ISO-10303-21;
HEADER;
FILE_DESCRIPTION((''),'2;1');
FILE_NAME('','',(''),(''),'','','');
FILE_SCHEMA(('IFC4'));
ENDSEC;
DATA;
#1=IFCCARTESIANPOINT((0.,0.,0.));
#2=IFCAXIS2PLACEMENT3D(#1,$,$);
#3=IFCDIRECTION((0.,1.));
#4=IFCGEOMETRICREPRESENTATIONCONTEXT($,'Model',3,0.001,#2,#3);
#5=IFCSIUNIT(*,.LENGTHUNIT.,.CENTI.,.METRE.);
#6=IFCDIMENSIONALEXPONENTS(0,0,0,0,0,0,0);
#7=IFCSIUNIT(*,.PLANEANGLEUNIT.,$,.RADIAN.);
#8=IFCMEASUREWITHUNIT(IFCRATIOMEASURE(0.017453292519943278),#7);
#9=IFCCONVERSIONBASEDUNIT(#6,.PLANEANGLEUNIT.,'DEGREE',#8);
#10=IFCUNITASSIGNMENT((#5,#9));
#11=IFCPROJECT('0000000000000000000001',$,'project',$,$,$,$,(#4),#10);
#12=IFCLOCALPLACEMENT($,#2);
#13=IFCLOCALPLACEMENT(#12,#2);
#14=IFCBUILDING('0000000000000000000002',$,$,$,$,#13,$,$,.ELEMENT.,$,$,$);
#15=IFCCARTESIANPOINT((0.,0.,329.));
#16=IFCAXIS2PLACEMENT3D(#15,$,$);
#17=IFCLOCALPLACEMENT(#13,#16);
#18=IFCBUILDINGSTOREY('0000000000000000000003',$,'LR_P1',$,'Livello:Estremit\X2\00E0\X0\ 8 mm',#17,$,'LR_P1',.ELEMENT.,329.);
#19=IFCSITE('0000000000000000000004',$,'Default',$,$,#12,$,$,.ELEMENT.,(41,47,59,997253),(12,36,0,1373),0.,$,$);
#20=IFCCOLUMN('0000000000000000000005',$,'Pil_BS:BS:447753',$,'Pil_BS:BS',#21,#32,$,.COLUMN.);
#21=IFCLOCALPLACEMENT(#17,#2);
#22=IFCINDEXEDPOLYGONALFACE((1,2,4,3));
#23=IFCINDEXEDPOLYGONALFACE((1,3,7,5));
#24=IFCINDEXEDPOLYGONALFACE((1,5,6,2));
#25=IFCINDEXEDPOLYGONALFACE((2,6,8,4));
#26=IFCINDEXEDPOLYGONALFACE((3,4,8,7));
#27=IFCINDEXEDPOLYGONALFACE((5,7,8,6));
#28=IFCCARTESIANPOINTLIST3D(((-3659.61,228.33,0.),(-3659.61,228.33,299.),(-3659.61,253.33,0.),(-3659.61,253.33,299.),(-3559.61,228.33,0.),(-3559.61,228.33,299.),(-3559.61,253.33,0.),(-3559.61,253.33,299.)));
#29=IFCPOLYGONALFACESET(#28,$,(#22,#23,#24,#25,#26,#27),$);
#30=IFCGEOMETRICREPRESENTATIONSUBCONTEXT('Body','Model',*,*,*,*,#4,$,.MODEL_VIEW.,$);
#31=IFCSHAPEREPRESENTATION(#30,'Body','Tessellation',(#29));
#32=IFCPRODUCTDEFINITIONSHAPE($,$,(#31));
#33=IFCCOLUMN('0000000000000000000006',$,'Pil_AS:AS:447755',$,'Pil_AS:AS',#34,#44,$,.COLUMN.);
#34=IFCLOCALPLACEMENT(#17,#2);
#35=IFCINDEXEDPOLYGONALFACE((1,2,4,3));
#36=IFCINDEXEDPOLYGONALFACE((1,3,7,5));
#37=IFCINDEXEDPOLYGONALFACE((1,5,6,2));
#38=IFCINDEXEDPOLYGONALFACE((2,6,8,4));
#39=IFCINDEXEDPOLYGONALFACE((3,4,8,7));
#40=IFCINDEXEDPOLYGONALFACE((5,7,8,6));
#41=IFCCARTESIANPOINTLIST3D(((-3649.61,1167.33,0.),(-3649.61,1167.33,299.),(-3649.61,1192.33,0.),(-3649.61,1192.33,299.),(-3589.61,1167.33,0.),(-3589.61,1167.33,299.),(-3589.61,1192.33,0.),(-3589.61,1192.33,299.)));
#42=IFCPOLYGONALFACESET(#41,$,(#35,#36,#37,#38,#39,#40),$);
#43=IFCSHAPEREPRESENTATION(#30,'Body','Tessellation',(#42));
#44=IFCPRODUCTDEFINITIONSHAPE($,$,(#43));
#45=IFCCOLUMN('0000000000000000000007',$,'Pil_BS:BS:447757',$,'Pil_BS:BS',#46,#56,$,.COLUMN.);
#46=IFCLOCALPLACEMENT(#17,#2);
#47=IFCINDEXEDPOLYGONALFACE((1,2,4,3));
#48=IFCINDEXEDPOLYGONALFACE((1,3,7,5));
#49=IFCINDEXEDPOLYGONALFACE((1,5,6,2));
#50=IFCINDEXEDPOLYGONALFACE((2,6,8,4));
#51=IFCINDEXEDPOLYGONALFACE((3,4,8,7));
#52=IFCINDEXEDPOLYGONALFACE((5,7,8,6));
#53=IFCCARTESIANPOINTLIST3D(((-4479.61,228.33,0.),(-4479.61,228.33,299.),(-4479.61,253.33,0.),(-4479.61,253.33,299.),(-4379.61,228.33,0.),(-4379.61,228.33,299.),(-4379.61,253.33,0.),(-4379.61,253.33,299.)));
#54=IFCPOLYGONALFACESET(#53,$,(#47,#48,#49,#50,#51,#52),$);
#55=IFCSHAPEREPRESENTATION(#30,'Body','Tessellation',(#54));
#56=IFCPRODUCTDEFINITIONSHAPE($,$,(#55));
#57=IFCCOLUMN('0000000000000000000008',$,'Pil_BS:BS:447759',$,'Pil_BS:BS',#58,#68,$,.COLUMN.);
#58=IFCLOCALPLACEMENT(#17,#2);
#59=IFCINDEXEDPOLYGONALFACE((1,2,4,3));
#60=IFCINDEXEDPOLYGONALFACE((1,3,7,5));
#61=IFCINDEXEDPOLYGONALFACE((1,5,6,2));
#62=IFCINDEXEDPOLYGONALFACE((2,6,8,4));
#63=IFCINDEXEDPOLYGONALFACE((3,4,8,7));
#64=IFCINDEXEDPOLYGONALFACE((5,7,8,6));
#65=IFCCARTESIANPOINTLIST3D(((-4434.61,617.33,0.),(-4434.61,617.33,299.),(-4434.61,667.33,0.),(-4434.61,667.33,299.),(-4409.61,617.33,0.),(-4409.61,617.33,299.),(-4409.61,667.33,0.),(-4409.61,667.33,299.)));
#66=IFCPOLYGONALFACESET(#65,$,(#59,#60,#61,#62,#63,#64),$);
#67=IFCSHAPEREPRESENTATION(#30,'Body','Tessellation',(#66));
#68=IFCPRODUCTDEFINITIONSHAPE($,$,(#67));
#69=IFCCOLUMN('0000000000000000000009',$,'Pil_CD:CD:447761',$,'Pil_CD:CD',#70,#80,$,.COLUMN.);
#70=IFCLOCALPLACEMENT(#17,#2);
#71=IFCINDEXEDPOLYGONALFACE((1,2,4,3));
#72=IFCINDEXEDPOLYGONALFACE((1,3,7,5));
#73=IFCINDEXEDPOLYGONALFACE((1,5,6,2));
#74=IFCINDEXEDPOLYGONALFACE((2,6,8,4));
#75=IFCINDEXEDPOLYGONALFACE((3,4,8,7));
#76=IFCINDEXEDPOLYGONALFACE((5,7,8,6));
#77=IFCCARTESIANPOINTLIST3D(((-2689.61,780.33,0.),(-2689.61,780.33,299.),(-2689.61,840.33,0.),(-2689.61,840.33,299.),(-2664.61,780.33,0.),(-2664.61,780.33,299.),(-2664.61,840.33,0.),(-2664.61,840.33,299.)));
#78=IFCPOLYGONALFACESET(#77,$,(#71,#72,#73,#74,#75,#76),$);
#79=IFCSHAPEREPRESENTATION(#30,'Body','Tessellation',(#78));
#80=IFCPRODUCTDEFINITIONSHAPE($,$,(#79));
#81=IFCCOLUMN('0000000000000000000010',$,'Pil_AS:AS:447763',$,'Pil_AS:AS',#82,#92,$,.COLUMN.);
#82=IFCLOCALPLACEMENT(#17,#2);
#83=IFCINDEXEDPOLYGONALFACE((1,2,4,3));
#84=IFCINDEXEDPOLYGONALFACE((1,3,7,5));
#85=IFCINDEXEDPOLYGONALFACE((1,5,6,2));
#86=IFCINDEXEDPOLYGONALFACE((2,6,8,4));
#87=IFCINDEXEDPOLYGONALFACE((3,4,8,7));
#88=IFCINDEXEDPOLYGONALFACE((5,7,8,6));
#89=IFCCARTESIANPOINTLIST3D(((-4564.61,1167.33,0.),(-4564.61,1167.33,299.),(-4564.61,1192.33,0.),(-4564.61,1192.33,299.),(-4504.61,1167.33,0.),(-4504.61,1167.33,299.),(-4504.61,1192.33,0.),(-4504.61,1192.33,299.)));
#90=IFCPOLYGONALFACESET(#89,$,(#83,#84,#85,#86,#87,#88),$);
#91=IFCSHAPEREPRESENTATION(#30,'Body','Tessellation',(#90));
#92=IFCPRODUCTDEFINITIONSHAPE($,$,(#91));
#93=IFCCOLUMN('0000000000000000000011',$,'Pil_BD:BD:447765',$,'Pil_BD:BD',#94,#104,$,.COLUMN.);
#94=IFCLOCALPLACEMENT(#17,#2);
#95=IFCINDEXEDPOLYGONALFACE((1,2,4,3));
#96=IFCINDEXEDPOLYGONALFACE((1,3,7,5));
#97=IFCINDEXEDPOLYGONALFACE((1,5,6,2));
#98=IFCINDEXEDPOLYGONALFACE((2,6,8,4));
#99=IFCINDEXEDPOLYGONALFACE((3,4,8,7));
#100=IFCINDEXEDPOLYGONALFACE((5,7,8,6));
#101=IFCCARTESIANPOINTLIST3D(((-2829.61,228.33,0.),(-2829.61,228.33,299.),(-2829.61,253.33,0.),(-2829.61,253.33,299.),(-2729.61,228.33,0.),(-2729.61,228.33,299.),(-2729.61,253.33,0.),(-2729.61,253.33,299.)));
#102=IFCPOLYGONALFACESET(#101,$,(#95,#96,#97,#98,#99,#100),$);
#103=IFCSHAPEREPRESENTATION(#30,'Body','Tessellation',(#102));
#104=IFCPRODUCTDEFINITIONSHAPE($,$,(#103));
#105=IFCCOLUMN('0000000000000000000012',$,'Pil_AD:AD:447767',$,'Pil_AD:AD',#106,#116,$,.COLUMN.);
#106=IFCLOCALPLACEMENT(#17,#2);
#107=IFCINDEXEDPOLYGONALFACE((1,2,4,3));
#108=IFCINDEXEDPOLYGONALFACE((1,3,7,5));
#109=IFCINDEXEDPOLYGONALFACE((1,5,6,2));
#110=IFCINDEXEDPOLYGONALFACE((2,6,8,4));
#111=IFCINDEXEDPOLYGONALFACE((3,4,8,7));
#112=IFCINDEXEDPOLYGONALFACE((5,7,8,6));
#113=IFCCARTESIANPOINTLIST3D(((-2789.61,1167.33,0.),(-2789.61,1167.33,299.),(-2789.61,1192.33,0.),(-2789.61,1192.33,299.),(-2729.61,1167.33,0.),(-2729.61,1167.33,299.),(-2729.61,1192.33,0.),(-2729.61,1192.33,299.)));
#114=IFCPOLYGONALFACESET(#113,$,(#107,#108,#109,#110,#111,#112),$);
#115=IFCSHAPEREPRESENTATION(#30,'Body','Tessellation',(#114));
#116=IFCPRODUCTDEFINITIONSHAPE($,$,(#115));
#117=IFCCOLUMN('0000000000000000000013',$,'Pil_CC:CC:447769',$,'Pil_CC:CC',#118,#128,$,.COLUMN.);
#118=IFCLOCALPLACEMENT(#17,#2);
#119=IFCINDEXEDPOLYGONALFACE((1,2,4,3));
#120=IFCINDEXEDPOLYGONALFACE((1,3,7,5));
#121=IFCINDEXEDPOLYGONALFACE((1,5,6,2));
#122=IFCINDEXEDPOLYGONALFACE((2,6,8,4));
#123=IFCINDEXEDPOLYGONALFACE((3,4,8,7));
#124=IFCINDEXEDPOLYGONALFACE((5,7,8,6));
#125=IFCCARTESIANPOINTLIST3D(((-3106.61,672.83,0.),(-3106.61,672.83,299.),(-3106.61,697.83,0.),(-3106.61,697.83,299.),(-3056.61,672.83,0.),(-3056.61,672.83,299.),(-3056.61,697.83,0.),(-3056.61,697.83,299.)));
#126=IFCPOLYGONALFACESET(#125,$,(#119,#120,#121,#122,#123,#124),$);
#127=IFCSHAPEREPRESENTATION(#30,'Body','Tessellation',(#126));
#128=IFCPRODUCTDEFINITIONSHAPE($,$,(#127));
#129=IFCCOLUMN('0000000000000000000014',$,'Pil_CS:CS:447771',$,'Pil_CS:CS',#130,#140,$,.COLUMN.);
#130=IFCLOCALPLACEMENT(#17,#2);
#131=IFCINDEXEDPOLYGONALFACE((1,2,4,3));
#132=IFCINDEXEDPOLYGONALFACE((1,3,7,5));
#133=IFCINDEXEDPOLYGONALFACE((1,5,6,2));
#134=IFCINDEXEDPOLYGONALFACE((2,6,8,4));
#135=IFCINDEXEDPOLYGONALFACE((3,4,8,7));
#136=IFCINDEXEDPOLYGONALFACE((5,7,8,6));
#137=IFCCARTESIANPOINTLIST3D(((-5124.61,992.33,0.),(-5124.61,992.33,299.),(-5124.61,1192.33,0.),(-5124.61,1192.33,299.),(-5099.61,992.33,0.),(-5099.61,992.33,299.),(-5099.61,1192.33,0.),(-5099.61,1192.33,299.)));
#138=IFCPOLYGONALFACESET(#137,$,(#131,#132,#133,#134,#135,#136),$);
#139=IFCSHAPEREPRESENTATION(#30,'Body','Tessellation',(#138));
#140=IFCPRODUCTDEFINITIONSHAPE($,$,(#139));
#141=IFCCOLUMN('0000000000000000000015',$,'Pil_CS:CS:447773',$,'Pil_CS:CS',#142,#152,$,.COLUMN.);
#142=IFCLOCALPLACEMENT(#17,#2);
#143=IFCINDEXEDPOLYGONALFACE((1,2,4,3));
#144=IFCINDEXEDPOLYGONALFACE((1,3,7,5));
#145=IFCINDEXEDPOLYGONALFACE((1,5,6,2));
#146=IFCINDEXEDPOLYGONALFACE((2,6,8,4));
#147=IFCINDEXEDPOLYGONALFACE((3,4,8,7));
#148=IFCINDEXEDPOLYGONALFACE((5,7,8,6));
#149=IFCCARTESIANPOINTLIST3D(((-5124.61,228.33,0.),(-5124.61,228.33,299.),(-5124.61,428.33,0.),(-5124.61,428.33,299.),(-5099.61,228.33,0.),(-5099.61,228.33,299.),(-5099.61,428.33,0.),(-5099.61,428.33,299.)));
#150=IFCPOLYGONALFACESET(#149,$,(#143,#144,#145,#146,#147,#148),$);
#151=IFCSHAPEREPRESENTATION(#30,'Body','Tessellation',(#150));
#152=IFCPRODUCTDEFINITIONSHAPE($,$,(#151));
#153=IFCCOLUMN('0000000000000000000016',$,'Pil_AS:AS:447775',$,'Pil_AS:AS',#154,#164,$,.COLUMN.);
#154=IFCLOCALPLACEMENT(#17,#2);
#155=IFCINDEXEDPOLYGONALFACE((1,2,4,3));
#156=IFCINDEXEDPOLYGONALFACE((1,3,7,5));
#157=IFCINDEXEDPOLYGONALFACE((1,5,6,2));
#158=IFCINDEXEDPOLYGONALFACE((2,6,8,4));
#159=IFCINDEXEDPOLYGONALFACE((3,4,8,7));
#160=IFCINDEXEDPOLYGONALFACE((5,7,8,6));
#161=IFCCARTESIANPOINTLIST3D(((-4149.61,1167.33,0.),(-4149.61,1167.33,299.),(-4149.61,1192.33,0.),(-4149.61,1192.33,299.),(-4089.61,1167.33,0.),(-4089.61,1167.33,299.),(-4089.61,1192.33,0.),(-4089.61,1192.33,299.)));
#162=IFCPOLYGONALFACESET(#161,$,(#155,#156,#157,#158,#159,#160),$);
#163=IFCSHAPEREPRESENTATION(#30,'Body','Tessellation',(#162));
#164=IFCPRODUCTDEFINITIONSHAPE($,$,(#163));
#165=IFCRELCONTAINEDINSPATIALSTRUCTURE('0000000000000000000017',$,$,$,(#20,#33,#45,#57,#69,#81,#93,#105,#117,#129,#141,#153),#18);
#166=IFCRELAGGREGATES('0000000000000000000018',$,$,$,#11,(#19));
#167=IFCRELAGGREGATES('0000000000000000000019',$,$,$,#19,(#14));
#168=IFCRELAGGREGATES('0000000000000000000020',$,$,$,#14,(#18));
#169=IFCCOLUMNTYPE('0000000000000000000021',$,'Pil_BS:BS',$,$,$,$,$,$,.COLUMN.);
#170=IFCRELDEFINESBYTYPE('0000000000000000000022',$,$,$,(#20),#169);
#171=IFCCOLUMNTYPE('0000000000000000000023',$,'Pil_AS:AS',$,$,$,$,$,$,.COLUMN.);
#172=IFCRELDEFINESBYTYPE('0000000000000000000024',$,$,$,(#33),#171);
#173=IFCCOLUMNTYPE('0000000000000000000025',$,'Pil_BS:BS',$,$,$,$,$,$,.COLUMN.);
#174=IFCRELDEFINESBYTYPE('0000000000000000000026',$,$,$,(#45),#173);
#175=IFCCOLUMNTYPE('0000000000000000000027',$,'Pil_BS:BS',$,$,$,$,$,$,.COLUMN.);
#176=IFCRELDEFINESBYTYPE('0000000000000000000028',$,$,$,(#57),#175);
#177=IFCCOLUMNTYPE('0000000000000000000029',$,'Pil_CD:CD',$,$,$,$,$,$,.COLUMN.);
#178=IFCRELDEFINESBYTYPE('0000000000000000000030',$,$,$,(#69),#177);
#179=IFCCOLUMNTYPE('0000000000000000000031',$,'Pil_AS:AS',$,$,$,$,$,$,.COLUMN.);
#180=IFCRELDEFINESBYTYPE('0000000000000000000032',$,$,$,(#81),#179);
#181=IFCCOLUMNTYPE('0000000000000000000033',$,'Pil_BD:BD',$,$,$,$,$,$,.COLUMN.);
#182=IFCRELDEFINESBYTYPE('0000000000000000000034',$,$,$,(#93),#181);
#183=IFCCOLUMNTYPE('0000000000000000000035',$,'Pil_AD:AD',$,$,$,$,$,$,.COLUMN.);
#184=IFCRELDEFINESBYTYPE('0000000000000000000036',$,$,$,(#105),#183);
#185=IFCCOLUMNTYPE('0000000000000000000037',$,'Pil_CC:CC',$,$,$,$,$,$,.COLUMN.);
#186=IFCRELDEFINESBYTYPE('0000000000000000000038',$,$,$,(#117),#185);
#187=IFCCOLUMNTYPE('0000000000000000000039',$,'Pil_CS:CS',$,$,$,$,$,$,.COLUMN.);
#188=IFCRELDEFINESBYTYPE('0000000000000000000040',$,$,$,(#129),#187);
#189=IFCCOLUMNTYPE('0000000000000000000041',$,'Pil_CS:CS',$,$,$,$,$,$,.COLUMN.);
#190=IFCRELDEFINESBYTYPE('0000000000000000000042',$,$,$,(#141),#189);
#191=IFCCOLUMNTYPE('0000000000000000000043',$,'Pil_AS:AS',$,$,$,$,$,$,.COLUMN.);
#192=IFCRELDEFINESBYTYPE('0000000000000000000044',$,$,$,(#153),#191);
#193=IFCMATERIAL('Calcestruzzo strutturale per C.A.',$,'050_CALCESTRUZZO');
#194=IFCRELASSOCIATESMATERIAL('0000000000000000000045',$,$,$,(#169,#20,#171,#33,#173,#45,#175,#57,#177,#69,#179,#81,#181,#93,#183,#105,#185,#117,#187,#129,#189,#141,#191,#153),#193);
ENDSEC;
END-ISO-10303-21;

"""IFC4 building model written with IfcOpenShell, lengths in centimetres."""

from ifc_helpers import new_model, entity, si_unit, converted_unit, direction, frame, origin, place, context, subcontext, project, spatial, indexed_curve, outline, extrude, source, transform, mapped, material, type_object, type_shapes, element, save


model = new_model("IFC4")

# Units and contexts
model_context = context("Model", 3, precision=0.001, world=origin(), true_north=direction((0.0, 1.0)))
body_context = subcontext(model_context, "Body", "Model", "MODEL_VIEW")
ifc_project = project(units=[si_unit("LENGTHUNIT", "METRE", prefix="CENTI"), converted_unit("PLANEANGLEUNIT", "DEGREE", entity("IfcRatioMeasure", 0.017453292519943278), si_unit("PLANEANGLEUNIT", "RADIAN"), dimensions=[0, 0, 0, 0, 0, 0, 0])], contexts=[model_context])

# Site, building, storey
site_placement = place(None, origin())
site = spatial("IfcSite", under=ifc_project, at=site_placement, Name="Default", CompositionType="ELEMENT", RefLatitude=(41, 47, 59, 997253), RefLongitude=(12, 36, 0, 1373), RefElevation=0.0)
building_placement = place(site_placement, origin())
building = spatial("IfcBuilding", under=site, at=building_placement, CompositionType="ELEMENT")
storey_placement = place(building_placement, frame((0.0, 0.0, 329.0)))
storey = spatial("IfcBuildingStorey", under=building, at=storey_placement, Name="LR_P1", ObjectType="Livello:Estremità 8 mm", LongName="LR_P1", CompositionType="ELEMENT", Elevation=329.0)

# Columns
ifc_material_1 = material(Name="Calcestruzzo strutturale per C.A.", Category="050_CALCESTRUZZO")
column_type_1 = type_object("IfcColumnType", Name="Pil_BS:BS", PredefinedType="COLUMN", material=ifc_material_1)
shared_shape_1 = source(origin(), body_context, "Body", "SweptSolid", [
    extrude(outline(indexed_curve([(-12.5, -50.0), (12.5, -50.0), (12.5, 50.0), (-12.5, 50.0), (-12.5, -50.0)], self_intersect=False)), frame((-3609.61, 240.83, 329.0), z_axis=(0.0, 0.0, 1.0), x_axis=(0.0, -1.0, 0.0)), (0.0, 0.0, 1.0), 299.0),
])
type_shapes(column_type_1, [shared_shape_1])
column_1_placement = place(storey_placement, frame((0.0, 0.0, -329.0)))
element("IfcColumn", 1, at=column_1_placement, inside=storey, type_object=column_type_1, material=ifc_material_1, Name="Pil_BS:BS:447753", ObjectType="Pil_BS:BS", PredefinedType="COLUMN", context=body_context, shape_type="MappedRepresentation", body=[
    mapped(shared_shape_1, transform((0.0, 0.0, 0.0), scale=1.0)),
])
column_type_2 = type_object("IfcColumnType", Name="Pil_AS:AS", PredefinedType="COLUMN", material=ifc_material_1)
shared_shape_2 = source(origin(), body_context, "Body", "SweptSolid", [
    extrude(outline(indexed_curve([(-12.5, -30.0), (12.5, -30.0), (12.5, 30.0), (-12.5, 30.0), (-12.5, -30.0)], self_intersect=False)), frame((-3619.61, 1179.83, 329.0), z_axis=(0.0, 0.0, 1.0), x_axis=(0.0, -1.0, 0.0)), (0.0, 0.0, 1.0), 299.0),
])
type_shapes(column_type_2, [shared_shape_2])
column_2_placement = place(storey_placement, frame((0.0, 0.0, -329.0)))
element("IfcColumn", 2, at=column_2_placement, inside=storey, type_object=column_type_2, material=ifc_material_1, Name="Pil_AS:AS:447755", ObjectType="Pil_AS:AS", PredefinedType="COLUMN", context=body_context, shape_type="MappedRepresentation", body=[
    mapped(shared_shape_2, transform((0.0, 0.0, 0.0), scale=1.0)),
])
column_type_3 = type_object("IfcColumnType", Name="Pil_BS:BS", PredefinedType="COLUMN", material=ifc_material_1)
shared_shape_3 = source(origin(), body_context, "Body", "SweptSolid", [
    extrude(outline(indexed_curve([(-12.5, -50.0), (12.5, -50.0), (12.5, 50.0), (-12.5, 50.0), (-12.5, -50.0)], self_intersect=False)), frame((-4429.61, 240.83, 329.0), z_axis=(0.0, 0.0, 1.0), x_axis=(0.0, -1.0, 0.0)), (0.0, 0.0, 1.0), 299.0),
])
type_shapes(column_type_3, [shared_shape_3])
column_3_placement = place(storey_placement, frame((0.0, 0.0, -329.0)))
element("IfcColumn", 3, at=column_3_placement, inside=storey, type_object=column_type_3, material=ifc_material_1, Name="Pil_BS:BS:447757", ObjectType="Pil_BS:BS", PredefinedType="COLUMN", context=body_context, shape_type="MappedRepresentation", body=[
    mapped(shared_shape_3, transform((0.0, 0.0, 0.0), scale=1.0)),
])
column_type_4 = type_object("IfcColumnType", Name="Pil_BS:BS", PredefinedType="COLUMN", material=ifc_material_1)
shared_shape_4 = source(origin(), body_context, "Body", "SweptSolid", [
    extrude(outline(indexed_curve([(-25.0, -12.5), (25.0, -12.5), (25.0, 12.5), (-25.0, 12.5), (-25.0, -12.5)], self_intersect=False)), frame((-4422.11, 642.33, 329.0), z_axis=(0.0, 0.0, 1.0), x_axis=(0.0, -1.0, 0.0)), (0.0, 0.0, 1.0), 299.0),
])
type_shapes(column_type_4, [shared_shape_4])
column_4_placement = place(storey_placement, frame((0.0, 0.0, -329.0)))
element("IfcColumn", 4, at=column_4_placement, inside=storey, type_object=column_type_4, material=ifc_material_1, Name="Pil_BS:BS:447759", ObjectType="Pil_BS:BS", PredefinedType="COLUMN", context=body_context, shape_type="MappedRepresentation", body=[
    mapped(shared_shape_4, transform((0.0, 0.0, 0.0), scale=1.0)),
])
column_type_5 = type_object("IfcColumnType", Name="Pil_CD:CD", PredefinedType="COLUMN", material=ifc_material_1)
shared_shape_5 = source(origin(), body_context, "Body", "SweptSolid", [
    extrude(outline(indexed_curve([(-30.0, -12.5), (30.0, -12.5), (30.0, 12.5), (-30.0, 12.5), (-30.0, -12.5)], self_intersect=False)), frame((-2677.11, 810.33, 329.0), z_axis=(0.0, 0.0, 1.0), x_axis=(0.0, -1.0, 0.0)), (0.0, 0.0, 1.0), 299.0),
])
type_shapes(column_type_5, [shared_shape_5])
column_5_placement = place(storey_placement, frame((0.0, 0.0, -329.0)))
element("IfcColumn", 5, at=column_5_placement, inside=storey, type_object=column_type_5, material=ifc_material_1, Name="Pil_CD:CD:447761", ObjectType="Pil_CD:CD", PredefinedType="COLUMN", context=body_context, shape_type="MappedRepresentation", body=[
    mapped(shared_shape_5, transform((0.0, 0.0, 0.0), scale=1.0)),
])
column_type_6 = type_object("IfcColumnType", Name="Pil_AS:AS", PredefinedType="COLUMN", material=ifc_material_1)
shared_shape_6 = source(origin(), body_context, "Body", "SweptSolid", [
    extrude(outline(indexed_curve([(-12.5, -30.0), (12.5, -30.0), (12.5, 30.0), (-12.5, 30.0), (-12.5, -30.0)], self_intersect=False)), frame((-4534.61, 1179.83, 329.0), z_axis=(0.0, 0.0, 1.0), x_axis=(0.0, -1.0, 0.0)), (0.0, 0.0, 1.0), 299.0),
])
type_shapes(column_type_6, [shared_shape_6])
column_6_placement = place(storey_placement, frame((0.0, 0.0, -329.0)))
element("IfcColumn", 6, at=column_6_placement, inside=storey, type_object=column_type_6, material=ifc_material_1, Name="Pil_AS:AS:447763", ObjectType="Pil_AS:AS", PredefinedType="COLUMN", context=body_context, shape_type="MappedRepresentation", body=[
    mapped(shared_shape_6, transform((0.0, 0.0, 0.0), scale=1.0)),
])
column_type_7 = type_object("IfcColumnType", Name="Pil_BD:BD", PredefinedType="COLUMN", material=ifc_material_1)
shared_shape_7 = source(origin(), body_context, "Body", "SweptSolid", [
    extrude(outline(indexed_curve([(-12.5, -50.0), (12.5, -50.0), (12.5, 50.0), (-12.5, 50.0), (-12.5, -50.0)], self_intersect=False)), frame((-2779.61, 240.83, 329.0), z_axis=(0.0, 0.0, 1.0), x_axis=(0.0, -1.0, 0.0)), (0.0, 0.0, 1.0), 299.0),
])
type_shapes(column_type_7, [shared_shape_7])
column_7_placement = place(storey_placement, frame((0.0, 0.0, -329.0)))
element("IfcColumn", 7, at=column_7_placement, inside=storey, type_object=column_type_7, material=ifc_material_1, Name="Pil_BD:BD:447765", ObjectType="Pil_BD:BD", PredefinedType="COLUMN", context=body_context, shape_type="MappedRepresentation", body=[
    mapped(shared_shape_7, transform((0.0, 0.0, 0.0), scale=1.0)),
])
column_type_8 = type_object("IfcColumnType", Name="Pil_AD:AD", PredefinedType="COLUMN", material=ifc_material_1)
shared_shape_8 = source(origin(), body_context, "Body", "SweptSolid", [
    extrude(outline(indexed_curve([(-12.5, -30.0), (12.5, -30.0), (12.5, 30.0), (-12.5, 30.0), (-12.5, -30.0)], self_intersect=False)), frame((-2759.61, 1179.83, 329.0), z_axis=(0.0, 0.0, 1.0), x_axis=(0.0, -1.0, 0.0)), (0.0, 0.0, 1.0), 299.0),
])
type_shapes(column_type_8, [shared_shape_8])
column_8_placement = place(storey_placement, frame((0.0, 0.0, -329.0)))
element("IfcColumn", 8, at=column_8_placement, inside=storey, type_object=column_type_8, material=ifc_material_1, Name="Pil_AD:AD:447767", ObjectType="Pil_AD:AD", PredefinedType="COLUMN", context=body_context, shape_type="MappedRepresentation", body=[
    mapped(shared_shape_8, transform((0.0, 0.0, 0.0), scale=1.0)),
])
column_type_9 = type_object("IfcColumnType", Name="Pil_CC:CC", PredefinedType="COLUMN", material=ifc_material_1)
shared_shape_9 = source(origin(), body_context, "Body", "SweptSolid", [
    extrude(outline(indexed_curve([(-12.5, -25.0), (12.5, -25.0), (12.5, 25.0), (-12.5, 25.0), (-12.5, -25.0)], self_intersect=False)), frame((-3081.61, 685.33, 329.0), z_axis=(0.0, 0.0, 1.0), x_axis=(0.0, -1.0, 0.0)), (0.0, 0.0, 1.0), 299.0),
])
type_shapes(column_type_9, [shared_shape_9])
column_9_placement = place(storey_placement, frame((0.0, 0.0, -329.0)))
element("IfcColumn", 9, at=column_9_placement, inside=storey, type_object=column_type_9, material=ifc_material_1, Name="Pil_CC:CC:447769", ObjectType="Pil_CC:CC", PredefinedType="COLUMN", context=body_context, shape_type="MappedRepresentation", body=[
    mapped(shared_shape_9, transform((0.0, 0.0, 0.0), scale=1.0)),
])
column_type_10 = type_object("IfcColumnType", Name="Pil_CS:CS", PredefinedType="COLUMN", material=ifc_material_1)
shared_shape_10 = source(origin(), body_context, "Body", "SweptSolid", [
    extrude(outline(indexed_curve([(-100.0, -12.5), (100.0, -12.5), (100.0, 12.5), (-100.0, 12.5), (-100.0, -12.5)], self_intersect=False)), frame((-5112.11, 1092.33, 329.0), z_axis=(0.0, 0.0, 1.0), x_axis=(0.0, -1.0, 0.0)), (0.0, 0.0, 1.0), 299.0),
])
type_shapes(column_type_10, [shared_shape_10])
column_10_placement = place(storey_placement, frame((0.0, 0.0, -329.0)))
element("IfcColumn", 10, at=column_10_placement, inside=storey, type_object=column_type_10, material=ifc_material_1, Name="Pil_CS:CS:447771", ObjectType="Pil_CS:CS", PredefinedType="COLUMN", context=body_context, shape_type="MappedRepresentation", body=[
    mapped(shared_shape_10, transform((0.0, 0.0, 0.0), scale=1.0)),
])
column_type_11 = type_object("IfcColumnType", Name="Pil_CS:CS", PredefinedType="COLUMN", material=ifc_material_1)
shared_shape_11 = source(origin(), body_context, "Body", "SweptSolid", [
    extrude(outline(indexed_curve([(-100.0, -12.5), (100.0, -12.5), (100.0, 12.5), (-100.0, 12.5), (-100.0, -12.5)], self_intersect=False)), frame((-5112.11, 328.33, 329.0), z_axis=(0.0, 0.0, 1.0), x_axis=(0.0, -1.0, 0.0)), (0.0, 0.0, 1.0), 299.0),
])
type_shapes(column_type_11, [shared_shape_11])
column_11_placement = place(storey_placement, frame((0.0, 0.0, -329.0)))
element("IfcColumn", 11, at=column_11_placement, inside=storey, type_object=column_type_11, material=ifc_material_1, Name="Pil_CS:CS:447773", ObjectType="Pil_CS:CS", PredefinedType="COLUMN", context=body_context, shape_type="MappedRepresentation", body=[
    mapped(shared_shape_11, transform((0.0, 0.0, 0.0), scale=1.0)),
])
column_type_12 = type_object("IfcColumnType", Name="Pil_AS:AS", PredefinedType="COLUMN", material=ifc_material_1)
shared_shape_12 = source(origin(), body_context, "Body", "SweptSolid", [
    extrude(outline(indexed_curve([(-12.5, -30.0), (12.5, -30.0), (12.5, 30.0), (-12.5, 30.0), (-12.5, -30.0)], self_intersect=False)), frame((-4119.61, 1179.83, 329.0), z_axis=(0.0, 0.0, 1.0), x_axis=(0.0, -1.0, 0.0)), (0.0, 0.0, 1.0), 299.0),
])
type_shapes(column_type_12, [shared_shape_12])
column_12_placement = place(storey_placement, frame((0.0, 0.0, -329.0)))
element("IfcColumn", 12, at=column_12_placement, inside=storey, type_object=column_type_12, material=ifc_material_1, Name="Pil_AS:AS:447775", ObjectType="Pil_AS:AS", PredefinedType="COLUMN", context=body_context, shape_type="MappedRepresentation", body=[
    mapped(shared_shape_12, transform((0.0, 0.0, 0.0), scale=1.0)),
])

save(model, "model.ifc")
